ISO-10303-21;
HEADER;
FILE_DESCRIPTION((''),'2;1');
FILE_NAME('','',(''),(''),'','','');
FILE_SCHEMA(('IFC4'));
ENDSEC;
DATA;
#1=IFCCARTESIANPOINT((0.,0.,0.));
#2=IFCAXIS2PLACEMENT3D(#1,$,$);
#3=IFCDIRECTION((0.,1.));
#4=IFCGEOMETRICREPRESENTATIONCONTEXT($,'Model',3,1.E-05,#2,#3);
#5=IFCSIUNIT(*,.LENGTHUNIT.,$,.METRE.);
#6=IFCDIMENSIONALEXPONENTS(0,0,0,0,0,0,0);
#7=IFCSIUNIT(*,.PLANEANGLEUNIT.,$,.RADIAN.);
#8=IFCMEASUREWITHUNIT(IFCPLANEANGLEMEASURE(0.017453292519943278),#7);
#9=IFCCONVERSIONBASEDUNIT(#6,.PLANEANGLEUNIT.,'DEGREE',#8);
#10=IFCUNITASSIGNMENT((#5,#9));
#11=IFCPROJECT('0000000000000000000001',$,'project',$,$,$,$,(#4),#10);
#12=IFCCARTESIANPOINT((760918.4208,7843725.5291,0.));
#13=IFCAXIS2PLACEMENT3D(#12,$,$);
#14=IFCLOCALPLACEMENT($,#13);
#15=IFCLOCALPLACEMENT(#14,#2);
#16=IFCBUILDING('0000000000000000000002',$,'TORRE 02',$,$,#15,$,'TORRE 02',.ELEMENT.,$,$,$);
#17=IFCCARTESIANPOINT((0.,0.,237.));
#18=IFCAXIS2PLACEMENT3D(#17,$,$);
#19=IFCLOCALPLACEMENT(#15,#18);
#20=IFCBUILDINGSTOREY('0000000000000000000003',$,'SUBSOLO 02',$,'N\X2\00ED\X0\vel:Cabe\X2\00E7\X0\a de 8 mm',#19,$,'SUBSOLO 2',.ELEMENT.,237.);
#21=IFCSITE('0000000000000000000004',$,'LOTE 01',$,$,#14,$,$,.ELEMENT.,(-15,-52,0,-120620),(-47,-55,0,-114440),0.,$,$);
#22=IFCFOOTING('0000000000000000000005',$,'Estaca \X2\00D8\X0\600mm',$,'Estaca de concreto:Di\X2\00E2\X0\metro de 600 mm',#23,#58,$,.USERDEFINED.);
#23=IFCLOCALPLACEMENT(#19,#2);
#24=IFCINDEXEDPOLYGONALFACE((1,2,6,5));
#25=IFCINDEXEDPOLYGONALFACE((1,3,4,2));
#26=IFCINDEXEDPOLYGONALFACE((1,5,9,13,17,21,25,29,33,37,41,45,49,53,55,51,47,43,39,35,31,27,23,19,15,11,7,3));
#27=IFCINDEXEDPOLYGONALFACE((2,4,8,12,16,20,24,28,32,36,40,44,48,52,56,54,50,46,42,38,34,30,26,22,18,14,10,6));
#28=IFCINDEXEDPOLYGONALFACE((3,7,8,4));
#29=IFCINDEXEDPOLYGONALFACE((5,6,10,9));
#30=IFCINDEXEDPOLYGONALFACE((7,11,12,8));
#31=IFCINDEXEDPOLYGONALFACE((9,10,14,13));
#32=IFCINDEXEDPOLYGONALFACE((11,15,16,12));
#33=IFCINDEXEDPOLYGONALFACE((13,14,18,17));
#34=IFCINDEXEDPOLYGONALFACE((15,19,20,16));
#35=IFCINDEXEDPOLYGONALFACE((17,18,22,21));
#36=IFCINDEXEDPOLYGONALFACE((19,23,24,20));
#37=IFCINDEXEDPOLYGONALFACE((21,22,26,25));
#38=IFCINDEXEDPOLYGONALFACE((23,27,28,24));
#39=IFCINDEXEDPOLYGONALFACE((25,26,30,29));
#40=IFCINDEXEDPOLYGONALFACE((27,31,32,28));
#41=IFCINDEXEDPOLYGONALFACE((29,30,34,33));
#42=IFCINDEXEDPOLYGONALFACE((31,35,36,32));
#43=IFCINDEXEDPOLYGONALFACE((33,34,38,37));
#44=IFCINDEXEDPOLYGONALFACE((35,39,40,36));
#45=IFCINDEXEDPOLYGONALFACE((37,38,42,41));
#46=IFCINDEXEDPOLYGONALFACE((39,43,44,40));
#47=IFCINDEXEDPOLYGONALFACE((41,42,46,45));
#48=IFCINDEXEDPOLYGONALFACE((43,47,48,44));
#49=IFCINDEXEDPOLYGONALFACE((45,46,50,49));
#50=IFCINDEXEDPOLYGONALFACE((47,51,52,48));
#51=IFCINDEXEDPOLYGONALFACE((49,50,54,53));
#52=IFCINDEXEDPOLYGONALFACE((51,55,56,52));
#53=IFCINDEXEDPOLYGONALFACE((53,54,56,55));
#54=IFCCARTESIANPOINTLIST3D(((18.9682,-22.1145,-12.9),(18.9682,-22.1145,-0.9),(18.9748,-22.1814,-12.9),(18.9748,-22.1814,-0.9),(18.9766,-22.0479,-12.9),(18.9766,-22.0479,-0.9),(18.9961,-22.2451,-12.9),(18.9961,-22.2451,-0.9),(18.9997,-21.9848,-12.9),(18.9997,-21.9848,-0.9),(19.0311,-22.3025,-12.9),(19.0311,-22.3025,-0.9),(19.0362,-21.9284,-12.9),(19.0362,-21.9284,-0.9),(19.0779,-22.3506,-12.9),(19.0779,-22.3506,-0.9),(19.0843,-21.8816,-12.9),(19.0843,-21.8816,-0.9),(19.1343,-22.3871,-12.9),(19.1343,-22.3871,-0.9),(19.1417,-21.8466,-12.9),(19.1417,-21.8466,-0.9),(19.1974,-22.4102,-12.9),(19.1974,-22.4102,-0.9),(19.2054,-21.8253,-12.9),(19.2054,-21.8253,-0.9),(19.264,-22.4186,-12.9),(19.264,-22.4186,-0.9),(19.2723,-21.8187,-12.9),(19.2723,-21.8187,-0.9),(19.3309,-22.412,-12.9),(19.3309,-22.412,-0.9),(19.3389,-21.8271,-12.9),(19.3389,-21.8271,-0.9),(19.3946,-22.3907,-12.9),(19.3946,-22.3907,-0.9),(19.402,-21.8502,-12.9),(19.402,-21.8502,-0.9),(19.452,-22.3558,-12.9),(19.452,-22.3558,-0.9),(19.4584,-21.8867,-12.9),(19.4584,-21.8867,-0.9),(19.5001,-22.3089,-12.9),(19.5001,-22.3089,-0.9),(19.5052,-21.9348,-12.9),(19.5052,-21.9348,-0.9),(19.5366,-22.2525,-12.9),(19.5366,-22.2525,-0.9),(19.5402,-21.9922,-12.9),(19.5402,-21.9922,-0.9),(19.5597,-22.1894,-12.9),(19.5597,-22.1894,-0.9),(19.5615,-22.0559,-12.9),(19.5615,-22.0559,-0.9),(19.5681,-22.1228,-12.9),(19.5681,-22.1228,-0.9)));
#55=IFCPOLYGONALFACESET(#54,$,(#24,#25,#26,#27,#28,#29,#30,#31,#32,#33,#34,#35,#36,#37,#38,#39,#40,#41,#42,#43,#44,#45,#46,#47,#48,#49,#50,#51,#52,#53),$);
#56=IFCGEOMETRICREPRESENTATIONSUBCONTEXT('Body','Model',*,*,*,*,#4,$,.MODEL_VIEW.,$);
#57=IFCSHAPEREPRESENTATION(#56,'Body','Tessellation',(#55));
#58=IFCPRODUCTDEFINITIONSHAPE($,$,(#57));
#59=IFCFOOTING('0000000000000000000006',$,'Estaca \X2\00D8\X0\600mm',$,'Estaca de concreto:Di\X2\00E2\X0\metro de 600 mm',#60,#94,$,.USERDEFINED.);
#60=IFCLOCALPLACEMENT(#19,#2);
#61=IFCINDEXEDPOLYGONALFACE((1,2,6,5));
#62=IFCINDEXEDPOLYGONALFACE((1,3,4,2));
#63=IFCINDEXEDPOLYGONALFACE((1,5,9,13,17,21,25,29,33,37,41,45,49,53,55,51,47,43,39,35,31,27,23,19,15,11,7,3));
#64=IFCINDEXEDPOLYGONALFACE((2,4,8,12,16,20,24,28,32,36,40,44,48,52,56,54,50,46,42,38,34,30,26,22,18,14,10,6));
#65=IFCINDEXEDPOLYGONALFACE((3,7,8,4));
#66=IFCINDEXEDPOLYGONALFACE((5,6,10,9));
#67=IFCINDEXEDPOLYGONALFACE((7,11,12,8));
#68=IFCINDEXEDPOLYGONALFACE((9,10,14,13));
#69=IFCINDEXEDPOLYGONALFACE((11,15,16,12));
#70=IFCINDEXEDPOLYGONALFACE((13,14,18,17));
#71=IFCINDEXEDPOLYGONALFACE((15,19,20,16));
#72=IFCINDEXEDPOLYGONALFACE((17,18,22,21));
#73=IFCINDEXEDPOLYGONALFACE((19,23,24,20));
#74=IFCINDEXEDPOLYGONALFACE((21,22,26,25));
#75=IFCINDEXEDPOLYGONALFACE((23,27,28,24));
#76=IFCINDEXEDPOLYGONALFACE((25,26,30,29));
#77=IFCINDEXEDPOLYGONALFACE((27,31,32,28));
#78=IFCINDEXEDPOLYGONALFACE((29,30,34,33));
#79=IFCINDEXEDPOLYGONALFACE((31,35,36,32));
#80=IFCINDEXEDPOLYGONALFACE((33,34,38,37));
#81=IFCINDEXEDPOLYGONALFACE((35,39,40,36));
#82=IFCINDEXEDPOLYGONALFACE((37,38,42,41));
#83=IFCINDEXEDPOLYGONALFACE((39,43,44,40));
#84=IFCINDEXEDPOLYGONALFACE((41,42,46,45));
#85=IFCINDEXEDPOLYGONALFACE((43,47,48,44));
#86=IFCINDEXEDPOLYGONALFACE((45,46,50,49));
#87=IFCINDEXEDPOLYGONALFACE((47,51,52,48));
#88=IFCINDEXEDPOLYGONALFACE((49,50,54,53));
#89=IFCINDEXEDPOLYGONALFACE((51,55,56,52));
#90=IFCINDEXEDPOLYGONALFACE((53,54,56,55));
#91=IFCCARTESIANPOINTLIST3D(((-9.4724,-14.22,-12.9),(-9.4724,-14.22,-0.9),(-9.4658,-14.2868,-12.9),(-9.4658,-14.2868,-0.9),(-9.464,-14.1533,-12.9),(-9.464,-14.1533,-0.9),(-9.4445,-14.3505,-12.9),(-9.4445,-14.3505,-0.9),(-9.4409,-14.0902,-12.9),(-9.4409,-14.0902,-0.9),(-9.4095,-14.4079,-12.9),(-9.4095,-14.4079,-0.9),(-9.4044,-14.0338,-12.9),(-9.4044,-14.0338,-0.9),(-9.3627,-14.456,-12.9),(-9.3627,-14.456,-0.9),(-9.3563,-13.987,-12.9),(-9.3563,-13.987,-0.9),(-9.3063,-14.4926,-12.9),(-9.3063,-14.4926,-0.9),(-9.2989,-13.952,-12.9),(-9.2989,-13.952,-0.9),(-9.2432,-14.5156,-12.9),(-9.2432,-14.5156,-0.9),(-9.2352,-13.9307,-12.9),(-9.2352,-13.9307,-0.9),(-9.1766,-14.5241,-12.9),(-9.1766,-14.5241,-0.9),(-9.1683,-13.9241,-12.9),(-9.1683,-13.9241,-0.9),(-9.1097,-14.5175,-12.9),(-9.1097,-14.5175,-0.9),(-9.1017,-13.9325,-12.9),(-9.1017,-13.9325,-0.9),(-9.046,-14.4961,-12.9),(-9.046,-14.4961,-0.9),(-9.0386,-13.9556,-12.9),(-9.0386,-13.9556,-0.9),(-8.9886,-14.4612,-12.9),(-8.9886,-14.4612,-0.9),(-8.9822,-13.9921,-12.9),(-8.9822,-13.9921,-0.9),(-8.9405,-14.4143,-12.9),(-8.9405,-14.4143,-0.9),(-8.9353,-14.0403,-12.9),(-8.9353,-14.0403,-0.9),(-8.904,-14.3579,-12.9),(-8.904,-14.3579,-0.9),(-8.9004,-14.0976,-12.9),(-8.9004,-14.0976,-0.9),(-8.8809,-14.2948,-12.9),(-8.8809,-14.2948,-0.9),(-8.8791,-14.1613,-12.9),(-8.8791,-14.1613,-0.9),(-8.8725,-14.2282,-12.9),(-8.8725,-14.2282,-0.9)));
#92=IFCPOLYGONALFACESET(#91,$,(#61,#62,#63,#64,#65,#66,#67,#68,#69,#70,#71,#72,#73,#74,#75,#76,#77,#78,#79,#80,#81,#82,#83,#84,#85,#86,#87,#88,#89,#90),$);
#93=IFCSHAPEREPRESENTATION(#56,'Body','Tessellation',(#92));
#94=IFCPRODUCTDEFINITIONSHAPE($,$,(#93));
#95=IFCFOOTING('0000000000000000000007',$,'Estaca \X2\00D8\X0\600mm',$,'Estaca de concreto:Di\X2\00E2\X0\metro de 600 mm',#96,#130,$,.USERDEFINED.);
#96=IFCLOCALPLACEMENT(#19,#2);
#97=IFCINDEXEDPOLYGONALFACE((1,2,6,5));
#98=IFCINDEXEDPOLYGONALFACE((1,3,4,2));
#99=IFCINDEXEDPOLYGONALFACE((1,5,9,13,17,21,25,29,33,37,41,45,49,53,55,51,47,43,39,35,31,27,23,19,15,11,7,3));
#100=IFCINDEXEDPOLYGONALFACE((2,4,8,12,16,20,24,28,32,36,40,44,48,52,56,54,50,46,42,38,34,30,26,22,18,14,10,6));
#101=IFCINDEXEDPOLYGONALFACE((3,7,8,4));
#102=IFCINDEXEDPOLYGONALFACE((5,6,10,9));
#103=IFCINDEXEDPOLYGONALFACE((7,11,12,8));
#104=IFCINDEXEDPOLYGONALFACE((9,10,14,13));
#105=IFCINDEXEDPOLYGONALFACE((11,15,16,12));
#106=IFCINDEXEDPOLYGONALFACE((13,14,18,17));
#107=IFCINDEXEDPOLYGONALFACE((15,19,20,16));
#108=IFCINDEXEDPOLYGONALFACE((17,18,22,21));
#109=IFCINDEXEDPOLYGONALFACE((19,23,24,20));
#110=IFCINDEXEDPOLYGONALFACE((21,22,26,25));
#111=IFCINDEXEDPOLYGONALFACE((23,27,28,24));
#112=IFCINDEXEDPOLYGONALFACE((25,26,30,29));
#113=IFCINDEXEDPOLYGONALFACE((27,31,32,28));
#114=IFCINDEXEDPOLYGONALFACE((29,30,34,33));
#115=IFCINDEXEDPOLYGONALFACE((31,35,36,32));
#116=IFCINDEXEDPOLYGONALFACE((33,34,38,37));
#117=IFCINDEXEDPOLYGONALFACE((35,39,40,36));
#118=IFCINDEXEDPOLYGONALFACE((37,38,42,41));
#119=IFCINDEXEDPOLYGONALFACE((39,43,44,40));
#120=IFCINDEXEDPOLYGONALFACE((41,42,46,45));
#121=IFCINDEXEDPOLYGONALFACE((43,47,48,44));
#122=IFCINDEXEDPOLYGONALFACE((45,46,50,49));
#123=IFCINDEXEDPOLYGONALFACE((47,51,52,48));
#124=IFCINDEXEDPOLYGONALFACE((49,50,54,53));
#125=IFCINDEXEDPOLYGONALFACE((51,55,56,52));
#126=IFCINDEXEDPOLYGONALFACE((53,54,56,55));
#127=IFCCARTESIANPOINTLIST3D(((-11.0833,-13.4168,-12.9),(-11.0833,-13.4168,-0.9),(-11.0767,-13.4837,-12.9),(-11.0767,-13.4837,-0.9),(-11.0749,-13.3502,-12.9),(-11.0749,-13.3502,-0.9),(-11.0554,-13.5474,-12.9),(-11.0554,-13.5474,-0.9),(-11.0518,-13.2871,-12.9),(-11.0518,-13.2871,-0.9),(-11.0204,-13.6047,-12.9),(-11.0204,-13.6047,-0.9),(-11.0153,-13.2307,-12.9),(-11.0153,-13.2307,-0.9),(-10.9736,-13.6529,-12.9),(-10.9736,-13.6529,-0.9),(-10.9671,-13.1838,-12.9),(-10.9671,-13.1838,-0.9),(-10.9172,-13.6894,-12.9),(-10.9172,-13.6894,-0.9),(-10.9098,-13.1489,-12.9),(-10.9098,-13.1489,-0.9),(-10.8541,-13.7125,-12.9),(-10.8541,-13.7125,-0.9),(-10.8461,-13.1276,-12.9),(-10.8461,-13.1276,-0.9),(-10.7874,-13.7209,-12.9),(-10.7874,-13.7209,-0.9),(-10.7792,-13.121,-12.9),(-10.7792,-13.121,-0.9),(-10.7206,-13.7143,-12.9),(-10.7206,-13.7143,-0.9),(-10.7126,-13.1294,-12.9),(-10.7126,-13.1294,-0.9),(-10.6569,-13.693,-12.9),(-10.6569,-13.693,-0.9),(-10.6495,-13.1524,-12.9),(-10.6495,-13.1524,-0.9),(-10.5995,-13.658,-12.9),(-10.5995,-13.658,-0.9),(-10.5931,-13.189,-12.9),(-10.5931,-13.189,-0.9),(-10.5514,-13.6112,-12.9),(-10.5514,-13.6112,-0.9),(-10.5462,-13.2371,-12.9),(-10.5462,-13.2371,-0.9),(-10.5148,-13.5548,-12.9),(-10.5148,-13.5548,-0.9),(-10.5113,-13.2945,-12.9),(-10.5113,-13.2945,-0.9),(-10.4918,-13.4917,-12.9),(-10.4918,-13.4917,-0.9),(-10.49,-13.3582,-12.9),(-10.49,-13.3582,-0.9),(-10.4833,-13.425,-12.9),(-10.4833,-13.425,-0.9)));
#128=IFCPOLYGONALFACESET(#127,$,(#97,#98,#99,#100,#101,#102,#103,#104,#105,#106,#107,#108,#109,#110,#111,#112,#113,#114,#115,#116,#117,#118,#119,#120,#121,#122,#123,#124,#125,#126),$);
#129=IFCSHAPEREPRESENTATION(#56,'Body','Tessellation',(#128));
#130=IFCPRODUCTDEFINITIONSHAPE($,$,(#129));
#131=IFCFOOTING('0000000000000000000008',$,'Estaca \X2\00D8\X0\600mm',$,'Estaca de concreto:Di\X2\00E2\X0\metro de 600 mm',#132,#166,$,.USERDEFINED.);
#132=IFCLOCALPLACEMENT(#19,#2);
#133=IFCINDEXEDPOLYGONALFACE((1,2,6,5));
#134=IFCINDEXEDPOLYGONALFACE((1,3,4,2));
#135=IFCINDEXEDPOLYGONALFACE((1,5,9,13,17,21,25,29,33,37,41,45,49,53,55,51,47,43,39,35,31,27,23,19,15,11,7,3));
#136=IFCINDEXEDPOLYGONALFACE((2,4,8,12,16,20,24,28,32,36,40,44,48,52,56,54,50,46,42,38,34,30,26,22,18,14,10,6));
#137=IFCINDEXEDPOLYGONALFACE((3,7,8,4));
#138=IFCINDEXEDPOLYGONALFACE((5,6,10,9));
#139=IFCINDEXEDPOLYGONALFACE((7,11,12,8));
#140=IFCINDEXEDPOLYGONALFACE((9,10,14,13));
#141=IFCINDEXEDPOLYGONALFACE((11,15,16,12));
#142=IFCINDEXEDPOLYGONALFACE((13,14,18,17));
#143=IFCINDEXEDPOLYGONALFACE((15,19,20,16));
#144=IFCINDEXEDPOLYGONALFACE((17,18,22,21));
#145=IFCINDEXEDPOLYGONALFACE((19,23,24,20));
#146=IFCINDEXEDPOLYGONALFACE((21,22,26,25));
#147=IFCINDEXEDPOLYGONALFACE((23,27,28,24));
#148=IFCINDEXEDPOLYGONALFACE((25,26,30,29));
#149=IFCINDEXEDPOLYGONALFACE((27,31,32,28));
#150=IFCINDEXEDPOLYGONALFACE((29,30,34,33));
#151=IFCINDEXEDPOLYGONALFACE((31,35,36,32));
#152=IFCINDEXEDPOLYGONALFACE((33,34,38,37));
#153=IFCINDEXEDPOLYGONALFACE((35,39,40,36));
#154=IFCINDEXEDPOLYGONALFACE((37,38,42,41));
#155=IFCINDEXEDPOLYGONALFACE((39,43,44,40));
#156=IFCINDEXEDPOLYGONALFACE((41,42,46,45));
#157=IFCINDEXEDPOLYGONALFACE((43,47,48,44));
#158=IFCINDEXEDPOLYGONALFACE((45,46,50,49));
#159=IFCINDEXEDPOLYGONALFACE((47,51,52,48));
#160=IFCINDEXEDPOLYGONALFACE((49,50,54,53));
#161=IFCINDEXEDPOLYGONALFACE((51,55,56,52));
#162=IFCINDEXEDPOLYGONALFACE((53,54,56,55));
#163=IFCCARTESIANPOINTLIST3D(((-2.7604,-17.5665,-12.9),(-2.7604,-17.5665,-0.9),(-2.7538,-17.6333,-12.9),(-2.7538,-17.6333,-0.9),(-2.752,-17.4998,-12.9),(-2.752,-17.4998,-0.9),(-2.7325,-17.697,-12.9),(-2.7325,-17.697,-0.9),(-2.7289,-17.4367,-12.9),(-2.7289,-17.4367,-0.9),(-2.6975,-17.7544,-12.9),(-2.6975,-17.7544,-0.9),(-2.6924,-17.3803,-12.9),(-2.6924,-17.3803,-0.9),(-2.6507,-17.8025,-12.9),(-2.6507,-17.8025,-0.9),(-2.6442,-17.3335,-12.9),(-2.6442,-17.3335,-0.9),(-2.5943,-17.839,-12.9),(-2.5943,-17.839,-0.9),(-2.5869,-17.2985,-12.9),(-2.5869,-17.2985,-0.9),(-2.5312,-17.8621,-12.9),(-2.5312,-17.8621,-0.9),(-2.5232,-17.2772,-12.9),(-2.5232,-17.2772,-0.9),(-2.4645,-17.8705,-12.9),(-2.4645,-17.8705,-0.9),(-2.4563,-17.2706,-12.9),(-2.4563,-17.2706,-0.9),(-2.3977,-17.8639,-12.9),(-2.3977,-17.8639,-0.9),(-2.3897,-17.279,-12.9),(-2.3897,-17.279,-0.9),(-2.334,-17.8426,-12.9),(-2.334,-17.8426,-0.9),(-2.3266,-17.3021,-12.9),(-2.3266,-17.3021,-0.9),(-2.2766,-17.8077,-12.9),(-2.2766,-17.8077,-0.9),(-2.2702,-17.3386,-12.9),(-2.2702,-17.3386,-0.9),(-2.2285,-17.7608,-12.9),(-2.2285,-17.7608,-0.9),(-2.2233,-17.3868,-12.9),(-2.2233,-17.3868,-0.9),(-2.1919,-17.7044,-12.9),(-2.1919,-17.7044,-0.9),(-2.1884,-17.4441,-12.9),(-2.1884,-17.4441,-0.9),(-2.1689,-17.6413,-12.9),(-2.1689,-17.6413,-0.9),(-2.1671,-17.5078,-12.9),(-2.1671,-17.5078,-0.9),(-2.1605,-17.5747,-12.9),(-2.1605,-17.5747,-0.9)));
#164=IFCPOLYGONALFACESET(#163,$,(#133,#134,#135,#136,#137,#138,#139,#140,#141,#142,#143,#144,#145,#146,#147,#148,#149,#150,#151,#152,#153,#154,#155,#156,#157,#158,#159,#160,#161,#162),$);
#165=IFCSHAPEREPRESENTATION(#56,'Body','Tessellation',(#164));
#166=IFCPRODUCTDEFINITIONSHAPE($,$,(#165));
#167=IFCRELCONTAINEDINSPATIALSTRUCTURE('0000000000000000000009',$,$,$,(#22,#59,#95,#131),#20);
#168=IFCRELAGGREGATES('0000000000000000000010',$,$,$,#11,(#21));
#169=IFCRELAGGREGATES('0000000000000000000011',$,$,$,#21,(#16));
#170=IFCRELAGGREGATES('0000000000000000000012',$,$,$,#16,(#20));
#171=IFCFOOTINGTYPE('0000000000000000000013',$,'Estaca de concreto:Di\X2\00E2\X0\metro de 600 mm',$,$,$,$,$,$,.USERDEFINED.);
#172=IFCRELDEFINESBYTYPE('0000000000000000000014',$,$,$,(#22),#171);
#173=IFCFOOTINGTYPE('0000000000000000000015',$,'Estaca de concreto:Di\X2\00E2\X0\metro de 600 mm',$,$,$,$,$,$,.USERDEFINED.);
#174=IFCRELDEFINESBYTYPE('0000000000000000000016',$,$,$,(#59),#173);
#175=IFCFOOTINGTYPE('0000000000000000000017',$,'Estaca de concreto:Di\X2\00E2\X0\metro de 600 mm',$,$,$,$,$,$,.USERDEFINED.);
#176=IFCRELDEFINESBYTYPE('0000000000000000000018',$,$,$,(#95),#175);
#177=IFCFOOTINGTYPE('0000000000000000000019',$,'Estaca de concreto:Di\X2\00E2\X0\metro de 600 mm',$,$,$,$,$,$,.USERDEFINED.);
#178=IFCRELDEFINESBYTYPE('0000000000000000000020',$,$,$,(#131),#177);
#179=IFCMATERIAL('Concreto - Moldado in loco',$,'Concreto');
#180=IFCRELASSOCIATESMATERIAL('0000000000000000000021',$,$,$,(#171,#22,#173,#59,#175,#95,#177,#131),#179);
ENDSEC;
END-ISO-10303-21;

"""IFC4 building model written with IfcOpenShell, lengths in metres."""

from ifc_helpers import new_model, entity, si_unit, converted_unit, direction, frame, origin, place, context, subcontext, project, spatial, arc, indexed_curve, outline, extrude, source, transform, mapped, material, type_object, type_shapes, element, save


model = new_model("IFC4")

# Units and contexts
model_context = context("Model", 3, precision=1e-05, world=origin(), true_north=direction((0.0, 1.0)))
body_context = subcontext(model_context, "Body", "Model", "MODEL_VIEW")
ifc_project = project(units=[si_unit("LENGTHUNIT", "METRE"), converted_unit("PLANEANGLEUNIT", "DEGREE", entity("IfcPlaneAngleMeasure", 0.017453292519943278), si_unit("PLANEANGLEUNIT", "RADIAN"), dimensions=[0, 0, 0, 0, 0, 0, 0])], contexts=[model_context])

# Site, building, storey
site_placement = place(None, frame((760918.4208, 7843725.5291, 0.0)))
site = spatial("IfcSite", under=ifc_project, at=site_placement, Name="LOTE 01", CompositionType="ELEMENT", RefLatitude=(-15, -52, 0, -120620), RefLongitude=(-47, -55, 0, -114440), RefElevation=0.0)
building_placement = place(site_placement, origin())
building = spatial("IfcBuilding", under=site, at=building_placement, Name="TORRE 02", LongName="TORRE 02", CompositionType="ELEMENT")
storey_placement = place(building_placement, frame((0.0, 0.0, 237.0)))
storey = spatial("IfcBuildingStorey", under=building, at=storey_placement, Name="SUBSOLO 02", ObjectType="Nível:Cabeça de 8 mm", LongName="SUBSOLO 2", CompositionType="ELEMENT", Elevation=237.0)

# Footings
ifc_material_1 = material(Name="Concreto - Moldado in loco", Category="Concreto")
placement = place(building_placement, frame((0.0, 0.0, 237.0)))
footing_type_1 = type_object("IfcFootingType", Name="Estaca de concreto:Diâmetro de 600 mm", PredefinedType="USERDEFINED", material=ifc_material_1)
shared_shape_1 = source(origin(), body_context, "Body", "SweptSolid", [
    extrude(outline(indexed_curve([(-0.3, 0.0), (0.0, -0.3), (0.3, 0.0), (0.0, 0.3)], segments=[arc(1, 2, 3), arc(3, 4, 1)], self_intersect=False)), frame((19.2681, -22.1187, -12.0), z_axis=(0.0, 0.0, 1.0), x_axis=(0.446198, 0.894934, 0.0)), (0.0, 0.0, 1.0), 12.0),
])
type_shapes(footing_type_1, [shared_shape_1])
footing_1_placement = place(placement, frame((0.0, 0.0, -0.9)))
element("IfcFooting", 1, at=footing_1_placement, inside=storey, type_object=footing_type_1, material=ifc_material_1, Name="Estaca Ø600mm", ObjectType="Estaca de concreto:Diâmetro de 600 mm", PredefinedType="USERDEFINED", context=body_context, shape_type="MappedRepresentation", body=[
    mapped(shared_shape_1, transform((0.0, 0.0, 0.0), scale=1.0)),
])
footing_type_2 = type_object("IfcFootingType", Name="Estaca de concreto:Diâmetro de 600 mm", PredefinedType="USERDEFINED", material=ifc_material_1)
shared_shape_2 = source(origin(), body_context, "Body", "SweptSolid", [
    extrude(outline(indexed_curve([(-0.3, 0.0), (0.0, -0.3), (0.3, 0.0), (0.0, 0.3)], segments=[arc(1, 2, 3), arc(3, 4, 1)], self_intersect=False)), frame((-9.1724, -14.2241, -12.0), z_axis=(0.0, 0.0, 1.0), x_axis=(-0.894934, 0.446198, 0.0)), (0.0, 0.0, 1.0), 12.0),
])
type_shapes(footing_type_2, [shared_shape_2])
footing_2_placement = place(placement, frame((0.0, 0.0, -0.9)))
element("IfcFooting", 2, at=footing_2_placement, inside=storey, type_object=footing_type_2, material=ifc_material_1, Name="Estaca Ø600mm", ObjectType="Estaca de concreto:Diâmetro de 600 mm", PredefinedType="USERDEFINED", context=body_context, shape_type="MappedRepresentation", body=[
    mapped(shared_shape_2, transform((0.0, 0.0, 0.0), scale=1.0)),
])
footing_type_3 = type_object("IfcFootingType", Name="Estaca de concreto:Diâmetro de 600 mm", PredefinedType="USERDEFINED", material=ifc_material_1)
shared_shape_3 = source(origin(), body_context, "Body", "SweptSolid", [
    extrude(outline(indexed_curve([(-0.3, 0.0), (0.0, -0.3), (0.3, 0.0), (0.0, 0.3)], segments=[arc(1, 2, 3), arc(3, 4, 1)], self_intersect=False)), frame((-10.7833, -13.4209, -12.0), z_axis=(0.0, 0.0, 1.0), x_axis=(-0.894934, 0.446198, 0.0)), (0.0, 0.0, 1.0), 12.0),
])
type_shapes(footing_type_3, [shared_shape_3])
footing_3_placement = place(placement, frame((0.0, 0.0, -0.9)))
element("IfcFooting", 3, at=footing_3_placement, inside=storey, type_object=footing_type_3, material=ifc_material_1, Name="Estaca Ø600mm", ObjectType="Estaca de concreto:Diâmetro de 600 mm", PredefinedType="USERDEFINED", context=body_context, shape_type="MappedRepresentation", body=[
    mapped(shared_shape_3, transform((0.0, 0.0, 0.0), scale=1.0)),
])
footing_type_4 = type_object("IfcFootingType", Name="Estaca de concreto:Diâmetro de 600 mm", PredefinedType="USERDEFINED", material=ifc_material_1)
shared_shape_4 = source(origin(), body_context, "Body", "SweptSolid", [
    extrude(outline(indexed_curve([(-0.3, 0.0), (0.0, -0.3), (0.3, 0.0), (0.0, 0.3)], segments=[arc(1, 2, 3), arc(3, 4, 1)], self_intersect=False)), frame((-2.4604, -17.5706, -12.0), z_axis=(0.0, 0.0, 1.0), x_axis=(-0.894934, 0.446198, 0.0)), (0.0, 0.0, 1.0), 12.0),
])
type_shapes(footing_type_4, [shared_shape_4])
footing_4_placement = place(placement, frame((0.0, 0.0, -0.9)))
element("IfcFooting", 4, at=footing_4_placement, inside=storey, type_object=footing_type_4, material=ifc_material_1, Name="Estaca Ø600mm", ObjectType="Estaca de concreto:Diâmetro de 600 mm", PredefinedType="USERDEFINED", context=body_context, shape_type="MappedRepresentation", body=[
    mapped(shared_shape_4, transform((0.0, 0.0, 0.0), scale=1.0)),
])

save(model, "model.ifc")
